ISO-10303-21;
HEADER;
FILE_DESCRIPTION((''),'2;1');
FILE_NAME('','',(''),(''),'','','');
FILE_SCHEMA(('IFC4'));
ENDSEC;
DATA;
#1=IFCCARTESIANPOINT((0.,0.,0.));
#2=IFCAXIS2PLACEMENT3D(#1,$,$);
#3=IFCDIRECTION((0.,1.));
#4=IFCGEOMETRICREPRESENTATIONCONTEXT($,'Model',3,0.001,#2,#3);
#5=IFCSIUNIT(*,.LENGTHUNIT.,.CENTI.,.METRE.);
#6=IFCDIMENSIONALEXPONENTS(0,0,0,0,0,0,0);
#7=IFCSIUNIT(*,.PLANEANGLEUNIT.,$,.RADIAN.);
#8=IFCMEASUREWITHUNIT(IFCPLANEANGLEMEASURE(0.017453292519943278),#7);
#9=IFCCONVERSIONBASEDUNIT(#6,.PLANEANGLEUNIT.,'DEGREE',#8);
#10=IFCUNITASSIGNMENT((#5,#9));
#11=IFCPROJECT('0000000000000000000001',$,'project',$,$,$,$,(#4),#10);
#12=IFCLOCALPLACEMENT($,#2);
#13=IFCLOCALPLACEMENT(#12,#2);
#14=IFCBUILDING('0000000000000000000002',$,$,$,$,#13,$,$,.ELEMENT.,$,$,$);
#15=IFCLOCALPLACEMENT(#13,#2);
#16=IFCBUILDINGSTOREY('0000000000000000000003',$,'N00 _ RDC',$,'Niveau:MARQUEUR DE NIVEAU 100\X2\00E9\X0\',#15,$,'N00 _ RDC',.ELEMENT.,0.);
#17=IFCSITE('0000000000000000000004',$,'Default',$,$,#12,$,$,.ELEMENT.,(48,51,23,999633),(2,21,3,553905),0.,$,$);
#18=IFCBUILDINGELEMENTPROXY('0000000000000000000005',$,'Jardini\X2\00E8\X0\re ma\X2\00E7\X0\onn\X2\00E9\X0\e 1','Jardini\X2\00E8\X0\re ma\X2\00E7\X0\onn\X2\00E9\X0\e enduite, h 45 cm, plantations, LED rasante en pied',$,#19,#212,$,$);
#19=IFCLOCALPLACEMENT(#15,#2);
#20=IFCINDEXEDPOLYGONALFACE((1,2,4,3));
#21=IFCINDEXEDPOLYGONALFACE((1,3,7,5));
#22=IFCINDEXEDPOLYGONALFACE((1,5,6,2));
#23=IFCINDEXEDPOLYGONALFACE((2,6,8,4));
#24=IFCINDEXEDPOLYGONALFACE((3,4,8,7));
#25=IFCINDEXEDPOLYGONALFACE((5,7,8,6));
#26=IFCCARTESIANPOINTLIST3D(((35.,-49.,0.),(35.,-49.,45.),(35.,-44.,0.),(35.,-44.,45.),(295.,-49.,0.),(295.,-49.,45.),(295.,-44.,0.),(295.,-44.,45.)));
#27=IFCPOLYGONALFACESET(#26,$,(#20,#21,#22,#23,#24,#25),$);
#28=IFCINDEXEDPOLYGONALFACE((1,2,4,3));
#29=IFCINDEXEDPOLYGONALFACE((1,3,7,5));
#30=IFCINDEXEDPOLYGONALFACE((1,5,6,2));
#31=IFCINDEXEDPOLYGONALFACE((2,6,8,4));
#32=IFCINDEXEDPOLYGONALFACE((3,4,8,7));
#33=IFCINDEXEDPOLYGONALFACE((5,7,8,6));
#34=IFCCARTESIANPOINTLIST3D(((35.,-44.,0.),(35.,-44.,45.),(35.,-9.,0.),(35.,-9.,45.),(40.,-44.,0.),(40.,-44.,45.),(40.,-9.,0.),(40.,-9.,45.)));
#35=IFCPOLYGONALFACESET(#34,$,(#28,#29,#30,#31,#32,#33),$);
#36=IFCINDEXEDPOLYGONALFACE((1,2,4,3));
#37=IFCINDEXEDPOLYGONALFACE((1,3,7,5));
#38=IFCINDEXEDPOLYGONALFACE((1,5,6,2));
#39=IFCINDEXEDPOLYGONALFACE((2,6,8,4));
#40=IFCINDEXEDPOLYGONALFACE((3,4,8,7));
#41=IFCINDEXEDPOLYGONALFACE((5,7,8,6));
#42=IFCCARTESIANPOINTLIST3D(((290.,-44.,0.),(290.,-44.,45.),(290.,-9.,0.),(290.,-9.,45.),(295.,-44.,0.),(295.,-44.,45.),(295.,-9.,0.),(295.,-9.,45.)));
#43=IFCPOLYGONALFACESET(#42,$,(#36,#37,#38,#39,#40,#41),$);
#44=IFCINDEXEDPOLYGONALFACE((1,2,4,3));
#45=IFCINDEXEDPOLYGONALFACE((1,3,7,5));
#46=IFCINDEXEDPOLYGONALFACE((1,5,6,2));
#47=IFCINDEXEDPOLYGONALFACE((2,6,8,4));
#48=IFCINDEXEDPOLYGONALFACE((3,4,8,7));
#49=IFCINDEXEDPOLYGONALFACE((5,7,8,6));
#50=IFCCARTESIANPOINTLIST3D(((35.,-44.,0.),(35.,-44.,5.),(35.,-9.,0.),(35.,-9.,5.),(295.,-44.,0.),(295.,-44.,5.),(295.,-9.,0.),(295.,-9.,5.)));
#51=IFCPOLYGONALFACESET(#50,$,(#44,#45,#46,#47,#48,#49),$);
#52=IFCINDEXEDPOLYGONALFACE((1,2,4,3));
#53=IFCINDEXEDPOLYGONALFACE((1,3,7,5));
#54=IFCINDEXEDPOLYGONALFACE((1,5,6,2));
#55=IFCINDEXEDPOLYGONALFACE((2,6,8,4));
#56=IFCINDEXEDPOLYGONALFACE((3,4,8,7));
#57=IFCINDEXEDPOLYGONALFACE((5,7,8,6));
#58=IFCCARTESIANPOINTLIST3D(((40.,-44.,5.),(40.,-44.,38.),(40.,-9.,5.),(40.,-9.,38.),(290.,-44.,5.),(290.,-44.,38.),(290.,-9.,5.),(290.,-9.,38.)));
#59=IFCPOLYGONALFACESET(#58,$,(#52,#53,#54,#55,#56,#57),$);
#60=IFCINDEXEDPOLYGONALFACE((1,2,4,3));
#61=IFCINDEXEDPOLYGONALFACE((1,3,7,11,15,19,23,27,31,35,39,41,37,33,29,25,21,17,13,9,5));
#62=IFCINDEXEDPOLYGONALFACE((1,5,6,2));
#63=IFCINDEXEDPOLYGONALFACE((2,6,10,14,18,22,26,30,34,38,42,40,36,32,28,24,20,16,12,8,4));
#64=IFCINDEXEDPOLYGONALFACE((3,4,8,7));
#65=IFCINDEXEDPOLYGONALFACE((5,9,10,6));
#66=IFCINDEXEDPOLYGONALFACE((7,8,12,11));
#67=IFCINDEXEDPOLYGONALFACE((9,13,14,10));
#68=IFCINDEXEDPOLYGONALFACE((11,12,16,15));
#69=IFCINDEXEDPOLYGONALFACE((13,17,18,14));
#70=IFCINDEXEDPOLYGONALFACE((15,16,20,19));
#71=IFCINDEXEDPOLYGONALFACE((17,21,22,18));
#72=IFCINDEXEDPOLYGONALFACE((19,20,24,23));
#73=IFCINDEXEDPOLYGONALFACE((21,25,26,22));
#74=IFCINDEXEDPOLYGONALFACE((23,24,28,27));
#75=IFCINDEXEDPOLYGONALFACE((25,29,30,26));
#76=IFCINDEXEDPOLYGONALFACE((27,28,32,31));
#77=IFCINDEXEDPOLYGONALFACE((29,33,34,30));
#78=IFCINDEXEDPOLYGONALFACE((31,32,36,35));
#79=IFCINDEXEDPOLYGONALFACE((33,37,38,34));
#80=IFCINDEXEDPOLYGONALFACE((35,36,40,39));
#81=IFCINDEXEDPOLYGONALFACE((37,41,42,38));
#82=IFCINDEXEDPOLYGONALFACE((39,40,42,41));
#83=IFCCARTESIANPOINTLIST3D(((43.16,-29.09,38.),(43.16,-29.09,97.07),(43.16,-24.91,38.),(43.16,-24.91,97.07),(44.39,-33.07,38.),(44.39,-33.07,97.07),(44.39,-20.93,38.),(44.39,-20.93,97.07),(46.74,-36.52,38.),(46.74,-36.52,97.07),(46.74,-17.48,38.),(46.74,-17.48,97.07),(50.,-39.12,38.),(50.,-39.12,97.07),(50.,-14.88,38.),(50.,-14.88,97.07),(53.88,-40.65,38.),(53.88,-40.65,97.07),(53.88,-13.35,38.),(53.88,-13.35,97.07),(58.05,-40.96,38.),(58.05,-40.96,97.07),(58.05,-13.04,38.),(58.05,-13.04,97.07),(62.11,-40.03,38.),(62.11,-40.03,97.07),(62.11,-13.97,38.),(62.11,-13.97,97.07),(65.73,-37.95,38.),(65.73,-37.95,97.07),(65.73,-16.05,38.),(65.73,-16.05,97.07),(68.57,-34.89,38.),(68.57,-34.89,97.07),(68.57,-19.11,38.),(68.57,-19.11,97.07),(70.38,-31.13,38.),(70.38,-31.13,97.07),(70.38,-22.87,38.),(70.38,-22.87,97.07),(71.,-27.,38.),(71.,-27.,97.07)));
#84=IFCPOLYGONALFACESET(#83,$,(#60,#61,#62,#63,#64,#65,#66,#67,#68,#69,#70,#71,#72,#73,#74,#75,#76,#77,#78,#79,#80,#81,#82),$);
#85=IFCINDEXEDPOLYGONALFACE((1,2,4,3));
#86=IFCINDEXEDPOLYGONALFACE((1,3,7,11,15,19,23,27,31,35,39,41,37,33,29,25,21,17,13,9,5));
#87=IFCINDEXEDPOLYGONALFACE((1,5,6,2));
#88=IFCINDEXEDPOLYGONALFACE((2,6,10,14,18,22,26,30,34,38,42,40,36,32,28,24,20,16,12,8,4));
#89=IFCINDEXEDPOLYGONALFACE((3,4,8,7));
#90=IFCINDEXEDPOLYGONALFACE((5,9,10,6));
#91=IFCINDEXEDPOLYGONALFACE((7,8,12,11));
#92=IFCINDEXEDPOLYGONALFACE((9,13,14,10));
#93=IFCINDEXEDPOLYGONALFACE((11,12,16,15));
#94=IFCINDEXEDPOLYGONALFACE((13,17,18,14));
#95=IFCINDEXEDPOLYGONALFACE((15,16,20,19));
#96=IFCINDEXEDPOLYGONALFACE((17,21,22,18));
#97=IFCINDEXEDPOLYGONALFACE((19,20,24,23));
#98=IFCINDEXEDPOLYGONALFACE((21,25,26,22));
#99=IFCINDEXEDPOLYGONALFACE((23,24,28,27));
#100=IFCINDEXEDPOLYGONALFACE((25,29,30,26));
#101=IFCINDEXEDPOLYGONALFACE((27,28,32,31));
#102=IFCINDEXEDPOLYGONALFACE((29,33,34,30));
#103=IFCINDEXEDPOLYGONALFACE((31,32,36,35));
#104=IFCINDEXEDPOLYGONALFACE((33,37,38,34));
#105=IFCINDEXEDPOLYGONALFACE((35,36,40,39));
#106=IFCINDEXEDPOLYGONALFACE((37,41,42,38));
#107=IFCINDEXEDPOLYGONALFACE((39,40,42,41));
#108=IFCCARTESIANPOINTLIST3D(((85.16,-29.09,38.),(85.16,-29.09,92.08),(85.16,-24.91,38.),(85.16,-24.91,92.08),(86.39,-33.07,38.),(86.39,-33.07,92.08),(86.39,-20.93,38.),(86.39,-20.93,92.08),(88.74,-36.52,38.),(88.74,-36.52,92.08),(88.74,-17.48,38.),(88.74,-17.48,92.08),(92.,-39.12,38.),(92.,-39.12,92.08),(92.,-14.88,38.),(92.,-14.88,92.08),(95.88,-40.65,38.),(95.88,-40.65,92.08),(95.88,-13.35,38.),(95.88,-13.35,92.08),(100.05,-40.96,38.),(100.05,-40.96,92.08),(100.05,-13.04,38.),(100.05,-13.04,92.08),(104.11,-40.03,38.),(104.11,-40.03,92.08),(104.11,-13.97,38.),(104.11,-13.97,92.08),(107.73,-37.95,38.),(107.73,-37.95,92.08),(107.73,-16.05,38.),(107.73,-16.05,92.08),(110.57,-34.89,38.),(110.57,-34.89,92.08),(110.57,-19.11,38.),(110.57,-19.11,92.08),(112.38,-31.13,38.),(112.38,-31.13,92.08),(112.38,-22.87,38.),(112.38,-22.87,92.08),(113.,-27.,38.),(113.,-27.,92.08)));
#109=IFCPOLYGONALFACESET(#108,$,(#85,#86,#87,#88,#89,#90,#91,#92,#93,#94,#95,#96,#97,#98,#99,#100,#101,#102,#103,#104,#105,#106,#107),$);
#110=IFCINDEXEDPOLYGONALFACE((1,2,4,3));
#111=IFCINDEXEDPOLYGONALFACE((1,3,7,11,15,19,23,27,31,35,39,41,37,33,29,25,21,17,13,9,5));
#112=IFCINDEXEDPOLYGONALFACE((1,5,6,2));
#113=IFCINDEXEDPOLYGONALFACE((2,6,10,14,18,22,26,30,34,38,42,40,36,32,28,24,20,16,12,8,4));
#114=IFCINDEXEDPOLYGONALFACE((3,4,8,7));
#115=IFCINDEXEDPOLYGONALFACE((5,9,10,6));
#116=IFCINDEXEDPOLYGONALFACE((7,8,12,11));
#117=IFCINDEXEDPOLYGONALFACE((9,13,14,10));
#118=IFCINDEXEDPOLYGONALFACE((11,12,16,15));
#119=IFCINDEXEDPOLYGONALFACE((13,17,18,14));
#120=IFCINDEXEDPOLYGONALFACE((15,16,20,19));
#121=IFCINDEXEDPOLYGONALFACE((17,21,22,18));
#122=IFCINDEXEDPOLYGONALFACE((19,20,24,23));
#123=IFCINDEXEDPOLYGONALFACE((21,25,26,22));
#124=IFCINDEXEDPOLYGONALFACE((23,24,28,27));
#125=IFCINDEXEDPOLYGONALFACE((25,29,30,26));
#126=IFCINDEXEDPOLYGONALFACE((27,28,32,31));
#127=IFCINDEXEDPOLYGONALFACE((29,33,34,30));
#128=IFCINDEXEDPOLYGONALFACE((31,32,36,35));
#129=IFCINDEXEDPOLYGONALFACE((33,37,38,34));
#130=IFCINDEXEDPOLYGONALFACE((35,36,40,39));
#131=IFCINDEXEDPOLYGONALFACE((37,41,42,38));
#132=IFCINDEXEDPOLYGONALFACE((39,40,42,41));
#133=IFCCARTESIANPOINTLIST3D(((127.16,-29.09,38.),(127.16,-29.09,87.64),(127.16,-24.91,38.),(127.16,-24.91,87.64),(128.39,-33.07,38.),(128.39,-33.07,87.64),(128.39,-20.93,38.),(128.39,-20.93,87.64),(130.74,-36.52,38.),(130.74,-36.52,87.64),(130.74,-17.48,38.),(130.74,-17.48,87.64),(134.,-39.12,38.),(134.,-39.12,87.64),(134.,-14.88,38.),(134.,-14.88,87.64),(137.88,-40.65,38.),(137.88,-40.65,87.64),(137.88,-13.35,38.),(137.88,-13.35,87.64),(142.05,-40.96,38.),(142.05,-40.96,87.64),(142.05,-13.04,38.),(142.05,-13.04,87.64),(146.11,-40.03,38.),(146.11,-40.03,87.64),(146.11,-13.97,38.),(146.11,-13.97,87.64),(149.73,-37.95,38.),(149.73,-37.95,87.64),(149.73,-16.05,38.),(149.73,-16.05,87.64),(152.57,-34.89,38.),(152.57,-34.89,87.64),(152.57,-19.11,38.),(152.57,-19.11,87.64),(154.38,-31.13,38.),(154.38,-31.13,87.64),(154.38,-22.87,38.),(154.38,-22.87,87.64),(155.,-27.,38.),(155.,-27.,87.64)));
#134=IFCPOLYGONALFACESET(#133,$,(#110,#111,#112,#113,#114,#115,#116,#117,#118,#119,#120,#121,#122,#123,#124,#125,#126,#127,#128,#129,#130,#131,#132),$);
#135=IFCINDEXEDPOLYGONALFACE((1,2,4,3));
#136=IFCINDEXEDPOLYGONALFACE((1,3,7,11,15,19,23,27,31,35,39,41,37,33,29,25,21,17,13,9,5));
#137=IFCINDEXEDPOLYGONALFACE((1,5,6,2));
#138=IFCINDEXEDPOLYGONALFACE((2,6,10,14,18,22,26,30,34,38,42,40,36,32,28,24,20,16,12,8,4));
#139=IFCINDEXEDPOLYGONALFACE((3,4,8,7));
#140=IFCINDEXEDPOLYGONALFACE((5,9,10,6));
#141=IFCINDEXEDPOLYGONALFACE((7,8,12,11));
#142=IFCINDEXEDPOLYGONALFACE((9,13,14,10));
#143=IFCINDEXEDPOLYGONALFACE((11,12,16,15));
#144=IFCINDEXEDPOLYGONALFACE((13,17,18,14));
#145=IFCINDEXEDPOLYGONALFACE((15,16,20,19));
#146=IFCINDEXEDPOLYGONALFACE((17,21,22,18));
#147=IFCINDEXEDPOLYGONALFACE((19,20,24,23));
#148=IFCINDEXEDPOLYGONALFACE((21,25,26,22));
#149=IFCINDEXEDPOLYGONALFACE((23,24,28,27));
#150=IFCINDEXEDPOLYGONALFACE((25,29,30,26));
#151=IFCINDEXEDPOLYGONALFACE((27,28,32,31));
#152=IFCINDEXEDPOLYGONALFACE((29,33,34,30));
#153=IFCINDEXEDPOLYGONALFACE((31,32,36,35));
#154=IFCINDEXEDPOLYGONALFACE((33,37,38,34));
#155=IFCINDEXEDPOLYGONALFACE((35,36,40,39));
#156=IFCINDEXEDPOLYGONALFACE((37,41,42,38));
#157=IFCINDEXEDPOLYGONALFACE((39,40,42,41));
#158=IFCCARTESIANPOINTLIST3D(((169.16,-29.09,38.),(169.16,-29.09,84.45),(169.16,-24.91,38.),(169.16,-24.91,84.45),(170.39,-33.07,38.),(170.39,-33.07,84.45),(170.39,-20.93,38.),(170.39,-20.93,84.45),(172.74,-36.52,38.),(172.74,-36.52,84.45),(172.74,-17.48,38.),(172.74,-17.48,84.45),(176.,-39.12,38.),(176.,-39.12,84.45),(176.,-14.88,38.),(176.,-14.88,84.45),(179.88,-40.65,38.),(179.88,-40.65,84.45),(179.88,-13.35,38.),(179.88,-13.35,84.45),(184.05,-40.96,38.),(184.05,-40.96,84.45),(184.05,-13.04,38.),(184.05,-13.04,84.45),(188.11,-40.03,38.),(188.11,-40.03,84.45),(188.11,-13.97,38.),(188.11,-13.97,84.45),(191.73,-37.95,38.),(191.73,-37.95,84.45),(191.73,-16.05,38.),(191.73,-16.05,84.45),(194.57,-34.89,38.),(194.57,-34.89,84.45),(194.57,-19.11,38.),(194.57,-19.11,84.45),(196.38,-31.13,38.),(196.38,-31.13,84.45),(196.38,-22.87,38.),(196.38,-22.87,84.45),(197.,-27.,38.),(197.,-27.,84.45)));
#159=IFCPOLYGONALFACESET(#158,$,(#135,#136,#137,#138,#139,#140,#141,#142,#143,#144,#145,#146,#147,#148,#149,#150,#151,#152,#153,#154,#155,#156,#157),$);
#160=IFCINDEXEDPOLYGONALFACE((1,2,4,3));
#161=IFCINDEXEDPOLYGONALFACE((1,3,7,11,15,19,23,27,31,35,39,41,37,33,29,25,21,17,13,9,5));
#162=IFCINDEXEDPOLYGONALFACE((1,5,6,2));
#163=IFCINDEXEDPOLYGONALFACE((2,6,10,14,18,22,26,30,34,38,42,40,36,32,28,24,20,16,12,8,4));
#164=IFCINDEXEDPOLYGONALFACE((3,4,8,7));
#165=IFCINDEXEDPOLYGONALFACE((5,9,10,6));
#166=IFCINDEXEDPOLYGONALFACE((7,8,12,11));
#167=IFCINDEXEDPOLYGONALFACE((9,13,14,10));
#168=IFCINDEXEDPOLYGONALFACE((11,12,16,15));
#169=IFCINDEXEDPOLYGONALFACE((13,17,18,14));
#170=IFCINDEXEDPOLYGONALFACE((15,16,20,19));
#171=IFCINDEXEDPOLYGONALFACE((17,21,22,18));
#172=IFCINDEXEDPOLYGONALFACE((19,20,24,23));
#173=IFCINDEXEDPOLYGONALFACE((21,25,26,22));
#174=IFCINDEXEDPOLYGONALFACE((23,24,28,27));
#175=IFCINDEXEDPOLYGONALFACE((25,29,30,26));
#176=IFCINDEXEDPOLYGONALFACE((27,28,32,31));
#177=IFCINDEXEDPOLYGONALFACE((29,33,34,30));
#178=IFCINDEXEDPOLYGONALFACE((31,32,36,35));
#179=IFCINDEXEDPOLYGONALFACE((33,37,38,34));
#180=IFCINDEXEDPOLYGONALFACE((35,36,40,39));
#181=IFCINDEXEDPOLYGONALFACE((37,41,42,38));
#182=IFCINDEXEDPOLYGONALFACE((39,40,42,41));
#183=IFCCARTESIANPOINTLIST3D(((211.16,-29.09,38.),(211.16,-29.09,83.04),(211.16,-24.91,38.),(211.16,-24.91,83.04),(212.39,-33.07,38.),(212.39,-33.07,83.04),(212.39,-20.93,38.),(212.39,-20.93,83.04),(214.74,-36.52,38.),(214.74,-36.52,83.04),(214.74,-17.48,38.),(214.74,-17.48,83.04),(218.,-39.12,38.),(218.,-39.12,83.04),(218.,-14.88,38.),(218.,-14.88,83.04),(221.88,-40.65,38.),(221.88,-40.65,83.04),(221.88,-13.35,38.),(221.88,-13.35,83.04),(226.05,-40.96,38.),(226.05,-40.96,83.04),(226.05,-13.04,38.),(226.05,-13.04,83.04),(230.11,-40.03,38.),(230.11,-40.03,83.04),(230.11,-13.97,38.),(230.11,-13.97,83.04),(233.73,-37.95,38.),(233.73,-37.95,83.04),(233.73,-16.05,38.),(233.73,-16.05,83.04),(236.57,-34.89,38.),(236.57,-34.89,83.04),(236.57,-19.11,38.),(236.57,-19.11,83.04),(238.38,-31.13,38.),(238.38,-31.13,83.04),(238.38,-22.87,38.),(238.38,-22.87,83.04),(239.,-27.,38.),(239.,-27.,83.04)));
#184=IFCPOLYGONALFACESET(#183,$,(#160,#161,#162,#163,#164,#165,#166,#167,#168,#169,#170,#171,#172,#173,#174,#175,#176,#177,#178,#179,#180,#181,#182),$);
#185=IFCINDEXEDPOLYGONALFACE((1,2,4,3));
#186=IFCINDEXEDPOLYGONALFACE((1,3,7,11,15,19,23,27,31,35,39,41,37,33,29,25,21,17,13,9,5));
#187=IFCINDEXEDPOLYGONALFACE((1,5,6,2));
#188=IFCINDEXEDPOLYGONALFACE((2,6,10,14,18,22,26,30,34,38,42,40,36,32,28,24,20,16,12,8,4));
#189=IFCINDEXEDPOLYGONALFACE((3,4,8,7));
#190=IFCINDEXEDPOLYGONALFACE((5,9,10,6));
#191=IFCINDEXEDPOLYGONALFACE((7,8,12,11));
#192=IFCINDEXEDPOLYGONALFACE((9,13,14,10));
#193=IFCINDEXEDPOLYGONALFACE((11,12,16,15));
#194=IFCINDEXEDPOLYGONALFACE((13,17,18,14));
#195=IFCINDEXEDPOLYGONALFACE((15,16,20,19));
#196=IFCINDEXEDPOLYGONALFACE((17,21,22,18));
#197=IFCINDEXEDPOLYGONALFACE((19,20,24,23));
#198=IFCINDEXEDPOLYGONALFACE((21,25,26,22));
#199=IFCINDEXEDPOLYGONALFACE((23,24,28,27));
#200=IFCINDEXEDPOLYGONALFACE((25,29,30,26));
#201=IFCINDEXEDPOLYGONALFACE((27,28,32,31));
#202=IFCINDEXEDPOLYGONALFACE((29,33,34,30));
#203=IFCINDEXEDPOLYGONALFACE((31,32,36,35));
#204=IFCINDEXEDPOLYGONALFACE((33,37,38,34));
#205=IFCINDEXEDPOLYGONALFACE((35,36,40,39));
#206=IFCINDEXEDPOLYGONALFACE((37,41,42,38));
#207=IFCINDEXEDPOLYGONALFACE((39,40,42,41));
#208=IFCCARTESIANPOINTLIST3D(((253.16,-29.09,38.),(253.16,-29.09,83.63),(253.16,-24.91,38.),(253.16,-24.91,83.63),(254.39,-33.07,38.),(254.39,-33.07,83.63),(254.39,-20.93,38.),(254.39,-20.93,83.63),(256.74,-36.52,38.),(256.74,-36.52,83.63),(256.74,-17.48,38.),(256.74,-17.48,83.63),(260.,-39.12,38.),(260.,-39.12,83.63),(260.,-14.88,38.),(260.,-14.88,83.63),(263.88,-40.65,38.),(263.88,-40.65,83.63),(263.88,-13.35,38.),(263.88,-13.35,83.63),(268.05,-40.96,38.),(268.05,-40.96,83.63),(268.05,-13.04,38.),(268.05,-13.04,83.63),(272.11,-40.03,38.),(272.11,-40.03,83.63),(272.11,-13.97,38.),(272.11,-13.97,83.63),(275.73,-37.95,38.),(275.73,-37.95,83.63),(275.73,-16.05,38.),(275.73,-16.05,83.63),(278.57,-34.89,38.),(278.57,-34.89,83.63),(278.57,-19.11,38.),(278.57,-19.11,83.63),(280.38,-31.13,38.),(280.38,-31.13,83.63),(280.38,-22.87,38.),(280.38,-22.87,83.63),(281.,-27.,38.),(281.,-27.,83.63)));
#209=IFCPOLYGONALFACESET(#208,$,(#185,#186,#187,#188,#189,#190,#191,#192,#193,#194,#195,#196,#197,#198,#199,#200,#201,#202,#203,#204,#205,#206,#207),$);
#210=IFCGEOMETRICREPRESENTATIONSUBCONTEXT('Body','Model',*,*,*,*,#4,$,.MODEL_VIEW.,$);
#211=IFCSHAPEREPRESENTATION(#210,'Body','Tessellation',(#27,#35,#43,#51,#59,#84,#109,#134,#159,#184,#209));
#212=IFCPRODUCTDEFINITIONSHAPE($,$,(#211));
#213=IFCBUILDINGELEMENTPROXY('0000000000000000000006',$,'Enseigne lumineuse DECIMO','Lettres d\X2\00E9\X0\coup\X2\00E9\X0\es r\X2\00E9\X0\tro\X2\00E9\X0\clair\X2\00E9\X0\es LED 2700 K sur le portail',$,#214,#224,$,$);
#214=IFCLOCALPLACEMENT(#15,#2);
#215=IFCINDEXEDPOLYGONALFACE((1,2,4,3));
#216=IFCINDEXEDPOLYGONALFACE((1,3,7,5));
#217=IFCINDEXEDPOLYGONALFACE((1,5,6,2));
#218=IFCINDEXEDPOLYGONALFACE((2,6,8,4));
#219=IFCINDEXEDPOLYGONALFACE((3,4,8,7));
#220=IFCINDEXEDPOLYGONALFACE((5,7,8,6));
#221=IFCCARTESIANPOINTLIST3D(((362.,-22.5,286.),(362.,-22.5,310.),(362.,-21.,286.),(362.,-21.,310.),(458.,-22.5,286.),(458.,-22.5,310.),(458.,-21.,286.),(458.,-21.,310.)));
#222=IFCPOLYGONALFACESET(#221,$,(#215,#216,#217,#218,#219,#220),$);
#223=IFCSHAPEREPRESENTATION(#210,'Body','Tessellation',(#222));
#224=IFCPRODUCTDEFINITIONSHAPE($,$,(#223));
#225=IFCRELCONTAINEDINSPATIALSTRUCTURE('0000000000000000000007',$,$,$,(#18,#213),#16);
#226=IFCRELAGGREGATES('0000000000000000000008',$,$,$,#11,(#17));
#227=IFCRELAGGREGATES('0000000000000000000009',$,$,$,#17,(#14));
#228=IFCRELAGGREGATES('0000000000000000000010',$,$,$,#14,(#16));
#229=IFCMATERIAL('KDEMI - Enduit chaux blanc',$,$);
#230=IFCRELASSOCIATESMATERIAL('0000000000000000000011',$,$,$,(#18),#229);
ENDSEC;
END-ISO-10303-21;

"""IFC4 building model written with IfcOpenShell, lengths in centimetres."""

from ifc_helpers import new_model, entity, si_unit, converted_unit, direction, frame, frame_2d, origin, origin_with_axes, place, context, subcontext, project, spatial, rectangle, circle, extrude, material, element, save


model = new_model("IFC4")

# Units and contexts
model_context = context("Model", 3, precision=0.001, world=origin(), true_north=direction((0.0, 1.0)))
body_context = subcontext(model_context, "Body", "Model", "MODEL_VIEW")
ifc_project = project(units=[si_unit("LENGTHUNIT", "METRE", prefix="CENTI"), converted_unit("PLANEANGLEUNIT", "DEGREE", entity("IfcPlaneAngleMeasure", 0.017453292519943278), si_unit("PLANEANGLEUNIT", "RADIAN"), dimensions=[0, 0, 0, 0, 0, 0, 0])], contexts=[model_context])

# Site, building, storey
site_placement = place(None, origin())
site = spatial("IfcSite", under=ifc_project, at=site_placement, Name="Default", CompositionType="ELEMENT", RefLatitude=(48, 51, 23, 999633), RefLongitude=(2, 21, 3, 553905), RefElevation=0.0)
building_placement = place(site_placement, origin())
building = spatial("IfcBuilding", under=site, at=building_placement, CompositionType="ELEMENT")
storey_placement = place(building_placement, origin())
storey = spatial("IfcBuildingStorey", under=building, at=storey_placement, Name="N00 _ RDC", ObjectType="Niveau:MARQUEUR DE NIVEAU 100é", LongName="N00 _ RDC", CompositionType="ELEMENT", Elevation=0.0)

# Building element proxies
ifc_material_1 = material(Name="KDEMI - Enduit chaux blanc")
proxy_1_placement = place(storey_placement, origin_with_axes())
element("IfcBuildingElementProxy", 1, at=proxy_1_placement, inside=storey, material=ifc_material_1, Name="Jardinière maçonnée 1", Description="Jardinière maçonnée enduite, h 45 cm, plantations, LED rasante en pied", context=body_context, shape_type="SweptSolid", body=[
    extrude(rectangle(XDim=260.0, YDim=5.0, at=frame_2d((165.0, -46.5))), origin(), (0.0, 0.0, 1.0), 45.0),
    extrude(rectangle(XDim=5.0, YDim=35.0, at=frame_2d((37.5, -26.5))), origin(), (0.0, 0.0, 1.0), 45.0),
    extrude(rectangle(XDim=5.0, YDim=35.0, at=frame_2d((292.5, -26.5))), origin(), (0.0, 0.0, 1.0), 45.0),
    extrude(rectangle(XDim=260.0, YDim=35.0, at=frame_2d((165.0, -26.5))), origin(), (0.0, 0.0, 1.0), 5.0),
    extrude(rectangle(XDim=250.0, YDim=35.0, at=frame_2d((165.0, -26.5))), frame((0.0, 0.0, 5.0)), (0.0, 0.0, 1.0), 33.0),
    extrude(circle(Radius=14.0, at=frame_2d((57.0, -27.0))), frame((0.0, 0.0, 38.0)), (0.0, 0.0, 1.0), 59.07),
    extrude(circle(Radius=14.0, at=frame_2d((99.0, -27.0))), frame((0.0, 0.0, 38.0)), (0.0, 0.0, 1.0), 54.08),
    extrude(circle(Radius=14.0, at=frame_2d((141.0, -27.0))), frame((0.0, 0.0, 38.0)), (0.0, 0.0, 1.0), 49.64),
    extrude(circle(Radius=14.0, at=frame_2d((183.0, -27.0))), frame((0.0, 0.0, 38.0)), (0.0, 0.0, 1.0), 46.45),
    extrude(circle(Radius=14.0, at=frame_2d((225.0, -27.0))), frame((0.0, 0.0, 38.0)), (0.0, 0.0, 1.0), 45.04),
    extrude(circle(Radius=14.0, at=frame_2d((267.0, -27.0))), frame((0.0, 0.0, 38.0)), (0.0, 0.0, 1.0), 45.63),
])
proxy_2_placement = place(storey_placement, origin_with_axes())
element("IfcBuildingElementProxy", 2, at=proxy_2_placement, inside=storey, Name="Enseigne lumineuse DECIMO", Description="Lettres découpées rétroéclairées LED 2700 K sur le portail", context=body_context, shape_type="SweptSolid", body=[
    extrude(rectangle(XDim=96.0, YDim=1.5, at=frame_2d((410.0, -21.75))), frame((0.0, 0.0, 286.0)), (0.0, 0.0, 1.0), 24.0),
])

save(model, "model.ifc")
